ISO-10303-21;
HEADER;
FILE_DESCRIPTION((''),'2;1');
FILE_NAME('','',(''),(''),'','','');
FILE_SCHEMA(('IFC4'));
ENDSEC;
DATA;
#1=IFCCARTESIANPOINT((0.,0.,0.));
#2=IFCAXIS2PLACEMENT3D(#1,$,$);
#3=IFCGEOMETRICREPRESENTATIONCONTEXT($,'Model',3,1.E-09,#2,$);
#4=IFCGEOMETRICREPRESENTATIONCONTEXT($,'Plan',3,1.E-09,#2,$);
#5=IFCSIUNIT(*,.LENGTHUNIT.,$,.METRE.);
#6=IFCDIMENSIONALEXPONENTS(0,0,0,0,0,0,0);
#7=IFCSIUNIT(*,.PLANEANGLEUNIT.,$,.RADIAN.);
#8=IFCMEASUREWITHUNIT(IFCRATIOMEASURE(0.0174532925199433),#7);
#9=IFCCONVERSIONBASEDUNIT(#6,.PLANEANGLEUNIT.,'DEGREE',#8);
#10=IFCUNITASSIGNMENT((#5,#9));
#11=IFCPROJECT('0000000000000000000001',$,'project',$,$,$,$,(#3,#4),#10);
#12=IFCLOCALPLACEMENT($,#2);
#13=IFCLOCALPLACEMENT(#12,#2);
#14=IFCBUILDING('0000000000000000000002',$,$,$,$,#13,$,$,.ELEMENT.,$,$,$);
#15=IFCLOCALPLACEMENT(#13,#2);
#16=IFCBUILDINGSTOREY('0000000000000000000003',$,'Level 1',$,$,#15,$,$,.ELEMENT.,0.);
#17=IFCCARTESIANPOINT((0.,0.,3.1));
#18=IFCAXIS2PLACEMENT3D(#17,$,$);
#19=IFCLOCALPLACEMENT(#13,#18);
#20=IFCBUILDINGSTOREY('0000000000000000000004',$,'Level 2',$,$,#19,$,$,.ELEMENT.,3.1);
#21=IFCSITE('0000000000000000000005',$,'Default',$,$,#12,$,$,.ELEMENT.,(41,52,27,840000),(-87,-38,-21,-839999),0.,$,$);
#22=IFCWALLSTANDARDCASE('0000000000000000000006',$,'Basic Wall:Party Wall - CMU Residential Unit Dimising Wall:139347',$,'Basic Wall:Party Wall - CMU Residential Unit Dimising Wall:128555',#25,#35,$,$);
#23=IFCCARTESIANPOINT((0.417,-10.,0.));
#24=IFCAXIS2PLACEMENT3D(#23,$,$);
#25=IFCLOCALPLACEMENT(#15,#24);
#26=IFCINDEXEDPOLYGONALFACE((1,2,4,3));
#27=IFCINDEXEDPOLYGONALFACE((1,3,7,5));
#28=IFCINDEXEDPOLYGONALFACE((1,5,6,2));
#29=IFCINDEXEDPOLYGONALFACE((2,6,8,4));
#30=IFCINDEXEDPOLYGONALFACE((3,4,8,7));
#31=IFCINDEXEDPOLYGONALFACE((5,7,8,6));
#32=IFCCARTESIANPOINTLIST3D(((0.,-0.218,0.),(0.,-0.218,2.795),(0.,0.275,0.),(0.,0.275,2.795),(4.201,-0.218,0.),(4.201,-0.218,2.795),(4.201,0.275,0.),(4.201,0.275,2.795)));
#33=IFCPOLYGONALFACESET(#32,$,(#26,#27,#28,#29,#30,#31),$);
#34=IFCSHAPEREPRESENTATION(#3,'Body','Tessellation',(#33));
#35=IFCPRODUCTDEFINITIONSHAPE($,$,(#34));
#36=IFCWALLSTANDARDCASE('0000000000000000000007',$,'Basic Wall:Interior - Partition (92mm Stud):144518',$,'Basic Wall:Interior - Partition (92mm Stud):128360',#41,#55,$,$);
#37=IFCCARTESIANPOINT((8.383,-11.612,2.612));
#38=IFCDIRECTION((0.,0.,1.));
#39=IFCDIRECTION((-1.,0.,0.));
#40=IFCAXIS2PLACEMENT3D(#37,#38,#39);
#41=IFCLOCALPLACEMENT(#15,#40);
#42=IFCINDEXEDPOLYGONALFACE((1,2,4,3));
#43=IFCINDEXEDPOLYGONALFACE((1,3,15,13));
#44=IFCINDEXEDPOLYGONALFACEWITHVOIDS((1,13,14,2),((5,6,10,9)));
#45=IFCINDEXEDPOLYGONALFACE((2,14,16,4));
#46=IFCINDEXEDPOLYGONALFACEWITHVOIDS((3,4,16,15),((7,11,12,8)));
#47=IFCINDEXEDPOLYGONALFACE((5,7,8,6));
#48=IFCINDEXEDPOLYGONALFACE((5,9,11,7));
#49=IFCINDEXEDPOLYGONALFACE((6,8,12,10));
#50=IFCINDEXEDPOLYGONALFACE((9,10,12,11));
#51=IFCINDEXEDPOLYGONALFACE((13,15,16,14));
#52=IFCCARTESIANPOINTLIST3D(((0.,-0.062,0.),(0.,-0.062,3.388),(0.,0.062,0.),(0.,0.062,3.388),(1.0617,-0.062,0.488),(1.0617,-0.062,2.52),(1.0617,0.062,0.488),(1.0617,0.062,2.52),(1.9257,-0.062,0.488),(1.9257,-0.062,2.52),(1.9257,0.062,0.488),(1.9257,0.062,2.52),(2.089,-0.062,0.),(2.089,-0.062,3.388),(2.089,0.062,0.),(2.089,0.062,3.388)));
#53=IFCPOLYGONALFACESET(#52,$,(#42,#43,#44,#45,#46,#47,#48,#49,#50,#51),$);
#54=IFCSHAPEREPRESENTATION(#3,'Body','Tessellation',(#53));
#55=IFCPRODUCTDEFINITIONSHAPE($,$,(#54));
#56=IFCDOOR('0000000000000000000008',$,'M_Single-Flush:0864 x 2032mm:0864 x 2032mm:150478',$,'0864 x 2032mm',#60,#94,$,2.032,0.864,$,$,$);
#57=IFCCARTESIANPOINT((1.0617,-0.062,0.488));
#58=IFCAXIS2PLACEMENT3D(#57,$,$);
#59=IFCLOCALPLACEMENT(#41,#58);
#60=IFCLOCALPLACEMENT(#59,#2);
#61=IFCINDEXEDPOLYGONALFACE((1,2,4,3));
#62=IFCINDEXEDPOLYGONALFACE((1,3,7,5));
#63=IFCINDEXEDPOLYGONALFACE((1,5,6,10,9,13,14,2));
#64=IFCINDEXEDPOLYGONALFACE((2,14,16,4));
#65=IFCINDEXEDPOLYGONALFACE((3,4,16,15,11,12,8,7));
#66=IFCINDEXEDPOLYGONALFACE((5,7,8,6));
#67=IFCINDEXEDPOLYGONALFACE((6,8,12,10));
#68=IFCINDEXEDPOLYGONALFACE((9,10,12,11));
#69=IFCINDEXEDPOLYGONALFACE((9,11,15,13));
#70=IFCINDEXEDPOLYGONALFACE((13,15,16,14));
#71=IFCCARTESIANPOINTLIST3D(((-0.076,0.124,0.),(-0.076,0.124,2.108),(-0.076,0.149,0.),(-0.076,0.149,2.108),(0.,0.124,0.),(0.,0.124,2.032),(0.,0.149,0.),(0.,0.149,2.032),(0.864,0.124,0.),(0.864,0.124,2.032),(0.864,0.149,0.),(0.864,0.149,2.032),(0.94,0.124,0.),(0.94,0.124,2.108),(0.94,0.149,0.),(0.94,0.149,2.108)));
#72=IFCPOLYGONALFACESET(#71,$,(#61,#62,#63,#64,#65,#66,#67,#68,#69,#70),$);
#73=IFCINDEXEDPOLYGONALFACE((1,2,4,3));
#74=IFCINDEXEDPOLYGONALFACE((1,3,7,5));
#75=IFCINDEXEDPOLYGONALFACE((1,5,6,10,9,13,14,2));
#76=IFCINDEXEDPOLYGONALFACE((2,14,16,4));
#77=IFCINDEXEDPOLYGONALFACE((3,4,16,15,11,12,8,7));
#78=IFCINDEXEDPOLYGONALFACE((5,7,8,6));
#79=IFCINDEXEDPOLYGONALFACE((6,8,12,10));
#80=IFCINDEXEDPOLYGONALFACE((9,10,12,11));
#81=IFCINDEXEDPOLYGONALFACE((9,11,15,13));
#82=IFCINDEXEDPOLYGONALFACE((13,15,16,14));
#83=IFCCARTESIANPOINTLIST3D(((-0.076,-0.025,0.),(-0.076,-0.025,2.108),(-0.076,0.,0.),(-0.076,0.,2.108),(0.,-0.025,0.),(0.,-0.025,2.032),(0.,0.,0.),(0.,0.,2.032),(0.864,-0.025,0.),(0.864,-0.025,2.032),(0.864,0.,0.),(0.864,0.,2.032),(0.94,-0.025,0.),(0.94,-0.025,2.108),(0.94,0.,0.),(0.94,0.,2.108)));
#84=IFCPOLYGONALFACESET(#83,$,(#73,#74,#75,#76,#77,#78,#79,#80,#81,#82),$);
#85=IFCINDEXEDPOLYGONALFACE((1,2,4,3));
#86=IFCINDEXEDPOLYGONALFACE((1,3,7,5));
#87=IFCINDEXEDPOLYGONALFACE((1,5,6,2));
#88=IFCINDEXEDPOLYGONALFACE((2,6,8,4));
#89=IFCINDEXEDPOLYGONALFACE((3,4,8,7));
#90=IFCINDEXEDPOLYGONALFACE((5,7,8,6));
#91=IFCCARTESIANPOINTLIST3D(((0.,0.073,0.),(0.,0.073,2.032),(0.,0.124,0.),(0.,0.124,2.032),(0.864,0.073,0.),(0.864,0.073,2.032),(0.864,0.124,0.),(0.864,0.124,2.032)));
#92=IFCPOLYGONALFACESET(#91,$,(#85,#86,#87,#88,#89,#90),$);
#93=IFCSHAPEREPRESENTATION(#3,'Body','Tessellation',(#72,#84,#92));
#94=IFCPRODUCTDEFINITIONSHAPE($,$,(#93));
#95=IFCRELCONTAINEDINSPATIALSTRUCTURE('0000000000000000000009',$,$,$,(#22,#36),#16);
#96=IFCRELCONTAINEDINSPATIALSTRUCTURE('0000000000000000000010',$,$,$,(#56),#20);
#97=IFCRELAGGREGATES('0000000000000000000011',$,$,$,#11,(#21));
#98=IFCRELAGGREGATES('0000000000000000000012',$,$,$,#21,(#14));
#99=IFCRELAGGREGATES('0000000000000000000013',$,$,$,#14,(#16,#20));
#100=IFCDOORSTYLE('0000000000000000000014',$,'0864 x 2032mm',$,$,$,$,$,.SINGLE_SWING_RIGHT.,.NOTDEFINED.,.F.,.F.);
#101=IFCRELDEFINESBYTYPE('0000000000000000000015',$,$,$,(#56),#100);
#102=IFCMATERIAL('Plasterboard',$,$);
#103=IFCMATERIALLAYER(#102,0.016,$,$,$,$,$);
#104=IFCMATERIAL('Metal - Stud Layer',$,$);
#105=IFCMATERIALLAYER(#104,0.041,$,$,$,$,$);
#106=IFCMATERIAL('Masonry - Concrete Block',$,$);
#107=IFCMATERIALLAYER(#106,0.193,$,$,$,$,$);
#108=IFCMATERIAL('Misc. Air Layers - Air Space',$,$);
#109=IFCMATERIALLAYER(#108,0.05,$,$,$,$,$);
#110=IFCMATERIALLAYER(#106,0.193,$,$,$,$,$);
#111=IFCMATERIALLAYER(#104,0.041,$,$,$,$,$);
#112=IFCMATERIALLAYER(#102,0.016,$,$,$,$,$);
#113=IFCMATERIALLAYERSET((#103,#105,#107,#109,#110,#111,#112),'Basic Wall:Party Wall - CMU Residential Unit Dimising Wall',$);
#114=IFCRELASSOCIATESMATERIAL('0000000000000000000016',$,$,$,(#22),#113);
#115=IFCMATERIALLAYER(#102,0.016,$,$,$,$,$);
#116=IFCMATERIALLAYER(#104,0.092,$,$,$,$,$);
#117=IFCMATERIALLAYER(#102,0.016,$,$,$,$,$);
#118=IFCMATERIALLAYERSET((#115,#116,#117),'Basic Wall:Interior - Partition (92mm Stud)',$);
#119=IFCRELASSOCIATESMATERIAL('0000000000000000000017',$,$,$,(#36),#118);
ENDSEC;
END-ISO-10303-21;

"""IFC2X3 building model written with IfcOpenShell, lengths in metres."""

from ifc_helpers import new_model, entity, si_unit, converted_unit, frame, frame_2d, origin, origin_2d_with_axis, place, context, project, spatial, polyline, rectangle, outline, extrude, clip, bounded_halfspace, source, transform, mapped, material, layer, layer_set, layer_usage, type_object, type_shapes, element, fill, save


model = new_model("IFC2X3")

# Units and contexts
model_context = context("Model", 3, precision=1e-09, world=origin())
plan_context = context("Plan", 3, precision=1e-09, world=origin())
ifc_project = project(units=[si_unit("LENGTHUNIT", "METRE"), converted_unit("PLANEANGLEUNIT", "DEGREE", entity("IfcRatioMeasure", 0.0174532925199433), si_unit("PLANEANGLEUNIT", "RADIAN"), dimensions=[0, 0, 0, 0, 0, 0, 0])], contexts=[model_context, plan_context])

# Site, building, storey
site_placement = place(None, origin())
site = spatial("IfcSite", under=ifc_project, at=site_placement, Name="Default", CompositionType="ELEMENT", RefLatitude=(41, 52, 27, 840000), RefLongitude=(-87, -38, -21, -839999), RefElevation=0.0)
building_placement = place(site_placement, origin())
building = spatial("IfcBuilding", under=site, at=building_placement, CompositionType="ELEMENT")
storey_1_placement = place(building_placement, origin())
storey_1 = spatial("IfcBuildingStorey", under=building, at=storey_1_placement, Name="Level 1", CompositionType="ELEMENT", Elevation=0.0)

# Shared definitions
ifc_material_1 = material(Name="Misc. Air Layers - Air Space")
ifc_material_2 = material(Name="Masonry - Concrete Block")
ifc_material_3 = material(Name="Metal - Stud Layer")
ifc_material_4 = material(Name="Plasterboard")

# Wall
ifc_layer_1 = layer(ifc_material_4, 0.016)
ifc_layer_2 = layer(ifc_material_3, 0.041)
ifc_layer_3 = layer(ifc_material_2, 0.193)
ifc_layer_4 = layer(ifc_material_1, 0.05)
ifc_layer_5 = layer(ifc_material_2, 0.193)
ifc_layer_6 = layer(ifc_material_3, 0.041)
ifc_layer_7 = layer(ifc_material_4, 0.016)
ifc_layer_set_1 = layer_set([ifc_layer_1, ifc_layer_2, ifc_layer_3, ifc_layer_4, ifc_layer_5, ifc_layer_6, ifc_layer_7], Name="Basic Wall:Party Wall - CMU Residential Unit Dimising Wall")
ifc_layer_usage_1 = layer_usage(ifc_layer_set_1, "AXIS2", "NEGATIVE", 0.275)
wall_1_placement = place(storey_1_placement, frame((0.417, -10.0, 0.0)))
element("IfcWallStandardCase", 1, at=wall_1_placement, inside=storey_1, material=ifc_layer_usage_1, Name="Basic Wall:Party Wall - CMU Residential Unit Dimising Wall:139347", ObjectType="Basic Wall:Party Wall - CMU Residential Unit Dimising Wall:128555", context=model_context, shape_type="Clipping", body=[
    clip(clip(extrude(rectangle(XDim=4.201, YDim=0.55, at=frame_2d((2.1005, 0.0), x_axis=(-1.0, 0.0))), origin(), (0.0, 0.0, 1.0), 2.795), bounded_halfspace(frame((0.0, -0.218, 0.0), z_axis=(0.0, 1.0, 0.0), x_axis=(-1.0, 0.0, 0.0)), True, frame((0.0, -0.218, 0.0), z_axis=(0.0, 1.0, 0.0), x_axis=(-1.0, 0.0, 0.0)), polyline([(0.0, 0.0), (0.0, 2.795), (-4.201, 2.795), (-4.201, 0.0), (0.0, 0.0)]))), bounded_halfspace(frame((4.201, 0.275, 0.0), z_axis=(-1.0, 0.0, 0.0), x_axis=(0.0, -1.0, 0.0)), True, frame((4.201, 0.275, 0.0), z_axis=(-1.0, 0.0, 0.0), x_axis=(0.0, -1.0, 0.0)), polyline([(0.0, 0.0), (0.493, 0.0), (0.493, 2.795), (0.0, 2.795), (0.0, 0.0)]))),
])

# Shared definitions
ifc_layer_8 = layer(ifc_material_4, 0.016)
ifc_layer_9 = layer(ifc_material_3, 0.092)
ifc_layer_10 = layer(ifc_material_4, 0.016)
ifc_layer_set_2 = layer_set([ifc_layer_8, ifc_layer_9, ifc_layer_10], Name="Basic Wall:Interior - Partition (92mm Stud)")

# Wall, opening
ifc_layer_usage_2 = layer_usage(ifc_layer_set_2, "AXIS2", "NEGATIVE", 0.062)
wall_2_placement = place(storey_1_placement, frame((8.383, -11.612, 2.612), z_axis=(0.0, 0.0, 1.0), x_axis=(-1.0, 0.0, 0.0)))
wall_2 = element("IfcWallStandardCase", 2, at=wall_2_placement, inside=storey_1, material=ifc_layer_usage_2, Name="Basic Wall:Interior - Partition (92mm Stud):144518", ObjectType="Basic Wall:Interior - Partition (92mm Stud):128360", context=model_context, shape_type="SweptSolid", body=[
    extrude(rectangle(XDim=2.089, YDim=0.124, at=frame_2d((1.0445, 0.0), x_axis=(-1.0, 0.0))), origin(), (0.0, 0.0, 1.0), 3.388),
])
opening_1_placement = place(wall_2_placement, frame((1.0617, -0.062, 0.488)))
opening_1 = element("IfcOpeningElement", 3, at=opening_1_placement, cuts=wall_2, ObjectType="Opening", context=model_context, shape_type="SweptSolid", body=[
    extrude(rectangle(XDim=0.864, YDim=2.032, at=frame_2d((1.016, 0.432), x_axis=(0.0, 1.0))), frame((0.0, 0.0, 0.0), z_axis=(0.0, 1.0, 0.0), x_axis=(0.0, 0.0, 1.0)), (0.0, 0.0, 1.0), 0.124),
])

# Shared definitions
storey_2_placement = place(building_placement, frame((0.0, 0.0, 3.1)))
storey_2 = spatial("IfcBuildingStorey", under=building, at=storey_2_placement, Name="Level 2", CompositionType="ELEMENT", Elevation=3.1)

# Door
door_style_1 = type_object("IfcDoorStyle", Name="0864 x 2032mm", ConstructionType="NOTDEFINED", OperationType="SINGLE_SWING_RIGHT", ParameterTakesPrecedence=False, Sizeable=False)
shared_shape_1 = source(origin(), model_context, "Body", "SweptSolid", [
    extrude(outline(polyline([(-0.508, -1.073), (0.508, -1.073), (0.508, 1.035), (0.432, 1.035), (0.432, -0.997), (-0.432, -0.997), (-0.432, 1.035), (-0.508, 1.035), (-0.508, -1.073)])), frame((0.432, 0.124, 1.035), z_axis=(0.0, 1.0, 0.0), x_axis=(1.0, 0.0, 0.0)), (0.0, 0.0, 1.0), 0.025),
    extrude(outline(polyline([(-1.073, -0.508), (1.035, -0.508), (1.035, -0.432), (-0.997, -0.432), (-0.997, 0.432), (1.035, 0.432), (1.035, 0.508), (-1.073, 0.508), (-1.073, -0.508)])), frame((0.432, -0.025, 1.035), z_axis=(0.0, 1.0, 0.0), x_axis=(0.0, 0.0, -1.0)), (0.0, 0.0, 1.0), 0.025),
    extrude(rectangle(XDim=0.051, YDim=0.864, at=origin_2d_with_axis()), frame((0.432, 0.0985, 0.0), z_axis=(0.0, 0.0, 1.0), x_axis=(0.0, 1.0, 0.0)), (0.0, 0.0, 1.0), 2.032),
])
type_shapes(door_style_1, [shared_shape_1])
door_1_placement = place(opening_1_placement, origin())
door_1 = element("IfcDoor", 4, at=door_1_placement, inside=storey_2, type_object=door_style_1, Name="M_Single-Flush:0864 x 2032mm:0864 x 2032mm:150478", ObjectType="0864 x 2032mm", OverallHeight=2.032, OverallWidth=0.864, context=model_context, shape_type="MappedRepresentation", body=[
    mapped(shared_shape_1, transform((0.0, 0.0, 0.0), scale=1.0)),
])
fill(opening_1, door_1)

save(model, "model.ifc")
